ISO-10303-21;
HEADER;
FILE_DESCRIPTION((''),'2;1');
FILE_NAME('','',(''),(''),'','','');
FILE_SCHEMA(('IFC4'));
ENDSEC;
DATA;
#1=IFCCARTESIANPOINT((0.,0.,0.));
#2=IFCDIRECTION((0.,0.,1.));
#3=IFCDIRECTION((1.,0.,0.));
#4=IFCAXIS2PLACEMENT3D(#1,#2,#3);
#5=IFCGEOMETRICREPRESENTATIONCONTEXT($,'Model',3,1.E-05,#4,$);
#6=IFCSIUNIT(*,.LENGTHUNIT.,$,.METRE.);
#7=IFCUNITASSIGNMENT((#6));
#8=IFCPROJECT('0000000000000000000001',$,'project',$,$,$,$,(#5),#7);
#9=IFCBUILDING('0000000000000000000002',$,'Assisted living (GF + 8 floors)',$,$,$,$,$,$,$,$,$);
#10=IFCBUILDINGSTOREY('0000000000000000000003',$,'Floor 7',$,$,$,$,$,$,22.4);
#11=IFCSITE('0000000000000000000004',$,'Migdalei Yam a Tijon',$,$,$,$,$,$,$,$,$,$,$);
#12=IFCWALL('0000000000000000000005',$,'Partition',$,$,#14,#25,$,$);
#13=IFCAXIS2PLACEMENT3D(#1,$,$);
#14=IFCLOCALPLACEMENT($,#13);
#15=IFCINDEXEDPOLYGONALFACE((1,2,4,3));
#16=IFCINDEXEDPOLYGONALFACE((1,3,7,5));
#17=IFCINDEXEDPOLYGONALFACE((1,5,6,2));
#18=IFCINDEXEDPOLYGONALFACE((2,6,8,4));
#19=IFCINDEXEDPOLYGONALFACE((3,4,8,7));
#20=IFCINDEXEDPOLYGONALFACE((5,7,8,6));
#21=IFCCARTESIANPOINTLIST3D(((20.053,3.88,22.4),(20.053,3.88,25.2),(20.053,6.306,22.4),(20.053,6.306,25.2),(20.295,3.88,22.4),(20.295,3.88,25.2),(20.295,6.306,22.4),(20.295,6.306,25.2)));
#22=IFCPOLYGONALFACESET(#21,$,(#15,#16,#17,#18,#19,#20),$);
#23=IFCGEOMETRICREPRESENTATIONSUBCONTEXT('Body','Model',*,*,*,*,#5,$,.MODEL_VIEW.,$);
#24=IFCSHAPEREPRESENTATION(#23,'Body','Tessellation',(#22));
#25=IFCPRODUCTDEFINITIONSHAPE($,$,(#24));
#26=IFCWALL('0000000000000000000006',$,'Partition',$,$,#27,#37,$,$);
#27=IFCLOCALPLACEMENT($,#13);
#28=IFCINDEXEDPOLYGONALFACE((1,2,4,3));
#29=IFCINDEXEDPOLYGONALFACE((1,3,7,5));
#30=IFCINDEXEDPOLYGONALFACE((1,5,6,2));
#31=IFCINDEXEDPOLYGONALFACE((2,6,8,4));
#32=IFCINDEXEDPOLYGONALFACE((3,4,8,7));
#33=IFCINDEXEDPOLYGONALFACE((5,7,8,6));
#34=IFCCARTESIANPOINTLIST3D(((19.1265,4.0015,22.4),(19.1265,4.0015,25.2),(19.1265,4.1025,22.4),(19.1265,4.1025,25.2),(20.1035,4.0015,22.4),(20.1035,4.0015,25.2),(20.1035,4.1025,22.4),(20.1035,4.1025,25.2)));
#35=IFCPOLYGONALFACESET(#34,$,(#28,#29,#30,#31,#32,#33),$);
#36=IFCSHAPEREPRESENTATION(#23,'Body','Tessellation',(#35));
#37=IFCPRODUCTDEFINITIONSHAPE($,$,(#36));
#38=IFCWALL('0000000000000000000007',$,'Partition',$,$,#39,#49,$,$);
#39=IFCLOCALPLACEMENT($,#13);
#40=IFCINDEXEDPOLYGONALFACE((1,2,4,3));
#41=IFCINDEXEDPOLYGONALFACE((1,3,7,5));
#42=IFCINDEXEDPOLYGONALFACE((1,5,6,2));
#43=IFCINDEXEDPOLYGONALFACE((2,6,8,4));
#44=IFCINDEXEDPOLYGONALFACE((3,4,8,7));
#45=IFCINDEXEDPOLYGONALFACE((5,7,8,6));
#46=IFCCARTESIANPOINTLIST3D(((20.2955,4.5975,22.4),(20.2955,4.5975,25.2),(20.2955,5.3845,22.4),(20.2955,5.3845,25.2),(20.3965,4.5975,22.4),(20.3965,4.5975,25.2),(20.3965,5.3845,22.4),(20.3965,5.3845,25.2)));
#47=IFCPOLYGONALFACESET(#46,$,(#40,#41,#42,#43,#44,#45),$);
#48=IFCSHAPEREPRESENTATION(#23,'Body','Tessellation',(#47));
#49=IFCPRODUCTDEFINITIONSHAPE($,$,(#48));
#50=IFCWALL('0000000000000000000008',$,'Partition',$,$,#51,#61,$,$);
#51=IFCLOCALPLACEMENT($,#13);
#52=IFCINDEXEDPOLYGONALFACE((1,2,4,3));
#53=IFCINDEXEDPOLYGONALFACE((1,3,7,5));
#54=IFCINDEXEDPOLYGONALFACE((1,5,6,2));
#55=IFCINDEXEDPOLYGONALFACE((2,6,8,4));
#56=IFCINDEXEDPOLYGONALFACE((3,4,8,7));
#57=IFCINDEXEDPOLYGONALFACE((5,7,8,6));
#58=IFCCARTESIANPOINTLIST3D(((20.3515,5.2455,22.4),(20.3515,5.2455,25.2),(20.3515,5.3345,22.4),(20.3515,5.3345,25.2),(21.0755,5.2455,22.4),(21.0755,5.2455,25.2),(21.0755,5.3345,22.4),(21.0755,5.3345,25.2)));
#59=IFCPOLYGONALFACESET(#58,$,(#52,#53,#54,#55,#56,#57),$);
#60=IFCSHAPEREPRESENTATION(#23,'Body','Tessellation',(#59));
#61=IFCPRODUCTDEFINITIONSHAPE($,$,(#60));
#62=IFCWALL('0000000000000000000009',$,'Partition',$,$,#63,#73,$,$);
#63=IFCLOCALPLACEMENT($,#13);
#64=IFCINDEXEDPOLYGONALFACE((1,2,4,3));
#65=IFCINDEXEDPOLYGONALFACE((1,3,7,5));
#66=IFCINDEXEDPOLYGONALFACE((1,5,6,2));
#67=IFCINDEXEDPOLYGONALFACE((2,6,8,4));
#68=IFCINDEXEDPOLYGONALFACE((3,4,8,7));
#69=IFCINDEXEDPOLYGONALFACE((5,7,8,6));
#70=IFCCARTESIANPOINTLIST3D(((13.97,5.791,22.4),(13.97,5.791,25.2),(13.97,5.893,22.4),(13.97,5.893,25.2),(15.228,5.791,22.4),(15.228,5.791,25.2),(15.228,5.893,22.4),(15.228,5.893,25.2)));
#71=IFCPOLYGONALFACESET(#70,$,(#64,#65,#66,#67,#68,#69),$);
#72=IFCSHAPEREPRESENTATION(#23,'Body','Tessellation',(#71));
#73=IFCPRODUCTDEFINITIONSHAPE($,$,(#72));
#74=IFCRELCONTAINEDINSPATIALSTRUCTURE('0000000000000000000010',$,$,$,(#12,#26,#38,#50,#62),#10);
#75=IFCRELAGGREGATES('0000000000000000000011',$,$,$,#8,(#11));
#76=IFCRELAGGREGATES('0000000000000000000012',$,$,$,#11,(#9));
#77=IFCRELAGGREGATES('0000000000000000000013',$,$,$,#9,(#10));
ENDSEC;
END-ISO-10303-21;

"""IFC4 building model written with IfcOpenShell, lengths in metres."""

from ifc_helpers import new_model, si_unit, frame, origin_with_axes, context, subcontext, project, spatial, line, indexed_curve, outline, extrude, element, save


model = new_model("IFC4")

# Units and contexts
model_context = context("Model", 3, precision=1e-05, world=origin_with_axes())
body_context = subcontext(model_context, "Body", "Model", "MODEL_VIEW")
ifc_project = project(units=[si_unit("LENGTHUNIT", "METRE")], contexts=[model_context])

# Site, building, storey
site = spatial("IfcSite", under=ifc_project, Name="Migdalei Yam a Tijon")
building = spatial("IfcBuilding", under=site, Name="Assisted living (GF + 8 floors)")
storey = spatial("IfcBuildingStorey", under=building, Name="Floor 7", Elevation=22.4)

# Walls
element("IfcWall", 1, inside=storey, Name="Partition", context=body_context, shape_type="SweptSolid", body=[
    extrude(outline(indexed_curve([(0.0, 0.0), (0.242, 0.0), (0.242, 2.426), (0.0, 2.426)], segments=[line(1, 2, 3, 4, 1)])), frame((20.053, 3.88, 22.4), z_axis=(0.0, 0.0, 1.0), x_axis=(1.0, 0.0, 0.0)), (0.0, 0.0, 1.0), 2.8),
])
element("IfcWall", 2, inside=storey, Name="Partition", context=body_context, shape_type="SweptSolid", body=[
    extrude(outline(indexed_curve([(0.0, 0.0), (0.977, 0.0), (0.977, 0.101), (0.0, 0.101)], segments=[line(1, 2, 3, 4, 1)])), frame((19.1265, 4.0015, 22.4), z_axis=(0.0, 0.0, 1.0), x_axis=(1.0, 0.0, 0.0)), (0.0, 0.0, 1.0), 2.8),
])
element("IfcWall", 3, inside=storey, Name="Partition", context=body_context, shape_type="SweptSolid", body=[
    extrude(outline(indexed_curve([(0.0, 0.0), (0.101, 0.0), (0.101, 0.787), (0.0, 0.787)], segments=[line(1, 2, 3, 4, 1)])), frame((20.2955, 4.5975, 22.4), z_axis=(0.0, 0.0, 1.0), x_axis=(1.0, 0.0, 0.0)), (0.0, 0.0, 1.0), 2.8),
])
element("IfcWall", 4, inside=storey, Name="Partition", context=body_context, shape_type="SweptSolid", body=[
    extrude(outline(indexed_curve([(0.0, 0.0), (0.724, 0.0), (0.724, 0.089), (0.0, 0.089)], segments=[line(1, 2, 3, 4, 1)])), frame((20.3515, 5.2455, 22.4), z_axis=(0.0, 0.0, 1.0), x_axis=(1.0, 0.0, 0.0)), (0.0, 0.0, 1.0), 2.8),
])
element("IfcWall", 5, inside=storey, Name="Partition", context=body_context, shape_type="SweptSolid", body=[
    extrude(outline(indexed_curve([(0.0, 0.0), (1.258, 0.0), (1.258, 0.102), (0.0, 0.102)], segments=[line(1, 2, 3, 4, 1)])), frame((13.97, 5.791, 22.4), z_axis=(0.0, 0.0, 1.0), x_axis=(1.0, 0.0, 0.0)), (0.0, 0.0, 1.0), 2.8),
])

save(model, "model.ifc")
